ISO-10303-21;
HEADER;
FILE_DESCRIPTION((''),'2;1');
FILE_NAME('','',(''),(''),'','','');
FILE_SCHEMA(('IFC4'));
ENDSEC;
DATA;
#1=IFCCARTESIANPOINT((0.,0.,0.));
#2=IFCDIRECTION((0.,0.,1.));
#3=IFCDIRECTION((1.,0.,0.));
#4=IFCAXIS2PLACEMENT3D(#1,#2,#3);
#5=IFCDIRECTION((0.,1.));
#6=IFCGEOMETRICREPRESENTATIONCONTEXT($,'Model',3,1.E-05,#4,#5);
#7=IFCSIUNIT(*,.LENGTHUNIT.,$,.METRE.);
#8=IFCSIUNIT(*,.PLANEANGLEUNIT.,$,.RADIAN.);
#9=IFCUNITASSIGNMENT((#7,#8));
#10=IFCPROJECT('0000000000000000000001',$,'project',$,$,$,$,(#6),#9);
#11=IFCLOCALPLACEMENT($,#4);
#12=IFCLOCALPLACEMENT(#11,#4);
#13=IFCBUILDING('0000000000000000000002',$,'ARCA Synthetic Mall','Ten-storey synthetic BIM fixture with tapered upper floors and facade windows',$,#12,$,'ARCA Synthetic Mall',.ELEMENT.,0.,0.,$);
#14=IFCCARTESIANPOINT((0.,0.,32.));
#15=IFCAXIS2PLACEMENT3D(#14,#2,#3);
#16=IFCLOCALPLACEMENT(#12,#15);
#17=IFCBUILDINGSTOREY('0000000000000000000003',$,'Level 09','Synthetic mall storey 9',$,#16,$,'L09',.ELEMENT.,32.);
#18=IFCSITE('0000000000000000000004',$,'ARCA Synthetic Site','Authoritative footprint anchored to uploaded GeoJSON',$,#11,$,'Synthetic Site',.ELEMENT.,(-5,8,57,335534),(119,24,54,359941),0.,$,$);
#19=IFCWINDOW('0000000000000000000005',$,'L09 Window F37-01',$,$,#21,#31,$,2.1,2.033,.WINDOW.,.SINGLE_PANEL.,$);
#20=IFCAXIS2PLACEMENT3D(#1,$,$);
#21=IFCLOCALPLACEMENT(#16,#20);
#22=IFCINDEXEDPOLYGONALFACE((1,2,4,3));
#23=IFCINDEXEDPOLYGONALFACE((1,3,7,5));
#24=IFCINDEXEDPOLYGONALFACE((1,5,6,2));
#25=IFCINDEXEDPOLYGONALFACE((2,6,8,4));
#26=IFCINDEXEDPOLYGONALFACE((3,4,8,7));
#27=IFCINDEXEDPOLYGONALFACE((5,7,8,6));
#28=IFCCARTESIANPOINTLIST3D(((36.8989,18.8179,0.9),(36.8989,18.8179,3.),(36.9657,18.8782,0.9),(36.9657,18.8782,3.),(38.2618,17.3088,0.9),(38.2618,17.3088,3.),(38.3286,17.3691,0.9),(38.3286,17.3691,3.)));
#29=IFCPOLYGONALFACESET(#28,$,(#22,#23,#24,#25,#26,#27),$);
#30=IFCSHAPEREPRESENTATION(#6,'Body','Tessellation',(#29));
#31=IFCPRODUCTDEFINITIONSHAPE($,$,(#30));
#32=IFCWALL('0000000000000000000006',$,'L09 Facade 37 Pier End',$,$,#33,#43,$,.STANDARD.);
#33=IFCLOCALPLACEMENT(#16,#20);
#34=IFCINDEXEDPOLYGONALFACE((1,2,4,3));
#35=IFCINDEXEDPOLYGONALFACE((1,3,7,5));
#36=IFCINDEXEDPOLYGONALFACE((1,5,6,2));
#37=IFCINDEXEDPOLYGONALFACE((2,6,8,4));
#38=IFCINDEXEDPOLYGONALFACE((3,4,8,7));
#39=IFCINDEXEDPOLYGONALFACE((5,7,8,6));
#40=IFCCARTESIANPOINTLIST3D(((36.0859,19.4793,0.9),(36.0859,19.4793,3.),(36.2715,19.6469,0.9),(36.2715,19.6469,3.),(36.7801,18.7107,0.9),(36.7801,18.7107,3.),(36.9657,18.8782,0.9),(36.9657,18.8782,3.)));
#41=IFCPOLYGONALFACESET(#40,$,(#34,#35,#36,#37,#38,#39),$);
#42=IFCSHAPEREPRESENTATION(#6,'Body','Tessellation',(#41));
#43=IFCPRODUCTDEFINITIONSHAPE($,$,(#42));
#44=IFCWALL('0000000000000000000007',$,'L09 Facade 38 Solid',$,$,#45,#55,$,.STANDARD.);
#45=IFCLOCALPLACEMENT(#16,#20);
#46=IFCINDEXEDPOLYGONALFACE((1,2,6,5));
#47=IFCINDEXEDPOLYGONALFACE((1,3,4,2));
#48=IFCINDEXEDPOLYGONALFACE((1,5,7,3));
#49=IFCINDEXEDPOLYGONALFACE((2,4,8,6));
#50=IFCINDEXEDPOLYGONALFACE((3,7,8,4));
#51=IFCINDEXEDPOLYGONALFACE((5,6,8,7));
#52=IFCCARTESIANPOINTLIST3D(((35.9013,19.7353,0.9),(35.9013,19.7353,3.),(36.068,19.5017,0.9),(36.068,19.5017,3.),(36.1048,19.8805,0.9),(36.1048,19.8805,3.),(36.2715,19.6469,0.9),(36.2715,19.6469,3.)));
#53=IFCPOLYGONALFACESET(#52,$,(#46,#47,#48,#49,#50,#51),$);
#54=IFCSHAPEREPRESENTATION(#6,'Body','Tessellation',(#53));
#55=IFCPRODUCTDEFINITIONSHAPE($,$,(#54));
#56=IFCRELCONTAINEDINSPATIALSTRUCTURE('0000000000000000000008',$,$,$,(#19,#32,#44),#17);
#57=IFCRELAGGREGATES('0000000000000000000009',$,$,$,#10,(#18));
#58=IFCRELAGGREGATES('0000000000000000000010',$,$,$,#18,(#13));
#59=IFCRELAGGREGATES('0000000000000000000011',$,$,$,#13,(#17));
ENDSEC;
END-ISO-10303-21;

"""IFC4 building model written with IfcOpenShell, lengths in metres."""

from ifc_helpers import new_model, si_unit, direction, frame, origin_with_axes, place, context, project, spatial, polyline, outline, extrude, element, save


model = new_model("IFC4")

# Units and contexts
model_context = context("Model", 3, precision=1e-05, world=origin_with_axes(), true_north=direction((0.0, 1.0)))
ifc_project = project(units=[si_unit("LENGTHUNIT", "METRE"), si_unit("PLANEANGLEUNIT", "RADIAN")], contexts=[model_context])

# Site, building, storey
site_placement = place(None, origin_with_axes())
site = spatial("IfcSite", under=ifc_project, at=site_placement, Name="ARCA Synthetic Site", Description="Authoritative footprint anchored to uploaded GeoJSON", LongName="Synthetic Site", CompositionType="ELEMENT", RefLatitude=(-5, 8, 57, 335534), RefLongitude=(119, 24, 54, 359941), RefElevation=0.0)
building_placement = place(site_placement, origin_with_axes())
building = spatial("IfcBuilding", under=site, at=building_placement, Name="ARCA Synthetic Mall", Description="Ten-storey synthetic BIM fixture with tapered upper floors and facade windows", LongName="ARCA Synthetic Mall", CompositionType="ELEMENT", ElevationOfRefHeight=0.0, ElevationOfTerrain=0.0)
storey_placement = place(building_placement, frame((0.0, 0.0, 32.0), z_axis=(0.0, 0.0, 1.0), x_axis=(1.0, 0.0, 0.0)))
storey = spatial("IfcBuildingStorey", under=building, at=storey_placement, Name="Level 09", Description="Synthetic mall storey 9", LongName="L09", CompositionType="ELEMENT", Elevation=32.0)

# Window
window_1_placement = place(storey_placement, frame((0.0, 0.0, 0.9), z_axis=(0.0, 0.0, 1.0), x_axis=(1.0, 0.0, 0.0)))
element("IfcWindow", 1, at=window_1_placement, inside=storey, Name="L09 Window F37-01", OverallHeight=2.1, OverallWidth=2.033, PartitioningType="SINGLE_PANEL", PredefinedType="WINDOW", context=model_context, shape_type="SweptSolid", body=[
    extrude(outline(polyline([(38.3286, 17.3691), (36.9657, 18.8782), (36.8989, 18.8179), (38.2618, 17.3088), (38.3286, 17.3691)])), origin_with_axes(), (0.0, 0.0, 1.0), 2.1),
])

# Walls
wall_1_placement = place(storey_placement, frame((0.0, 0.0, 0.9), z_axis=(0.0, 0.0, 1.0), x_axis=(1.0, 0.0, 0.0)))
element("IfcWall", 2, at=wall_1_placement, inside=storey, Name="L09 Facade 37 Pier End", PredefinedType="STANDARD", context=model_context, shape_type="SweptSolid", body=[
    extrude(outline(polyline([(36.9657, 18.8782), (36.2715, 19.6469), (36.0859, 19.4793), (36.7801, 18.7107), (36.9657, 18.8782)])), origin_with_axes(), (0.0, 0.0, 1.0), 2.1),
])
wall_2_placement = place(storey_placement, frame((0.0, 0.0, 0.9), z_axis=(0.0, 0.0, 1.0), x_axis=(1.0, 0.0, 0.0)))
element("IfcWall", 3, at=wall_2_placement, inside=storey, Name="L09 Facade 38 Solid", PredefinedType="STANDARD", context=model_context, shape_type="SweptSolid", body=[
    extrude(outline(polyline([(36.2715, 19.6469), (36.1048, 19.8805), (35.9013, 19.7353), (36.068, 19.5017), (36.2715, 19.6469)])), origin_with_axes(), (0.0, 0.0, 1.0), 2.1),
])

save(model, "model.ifc")
